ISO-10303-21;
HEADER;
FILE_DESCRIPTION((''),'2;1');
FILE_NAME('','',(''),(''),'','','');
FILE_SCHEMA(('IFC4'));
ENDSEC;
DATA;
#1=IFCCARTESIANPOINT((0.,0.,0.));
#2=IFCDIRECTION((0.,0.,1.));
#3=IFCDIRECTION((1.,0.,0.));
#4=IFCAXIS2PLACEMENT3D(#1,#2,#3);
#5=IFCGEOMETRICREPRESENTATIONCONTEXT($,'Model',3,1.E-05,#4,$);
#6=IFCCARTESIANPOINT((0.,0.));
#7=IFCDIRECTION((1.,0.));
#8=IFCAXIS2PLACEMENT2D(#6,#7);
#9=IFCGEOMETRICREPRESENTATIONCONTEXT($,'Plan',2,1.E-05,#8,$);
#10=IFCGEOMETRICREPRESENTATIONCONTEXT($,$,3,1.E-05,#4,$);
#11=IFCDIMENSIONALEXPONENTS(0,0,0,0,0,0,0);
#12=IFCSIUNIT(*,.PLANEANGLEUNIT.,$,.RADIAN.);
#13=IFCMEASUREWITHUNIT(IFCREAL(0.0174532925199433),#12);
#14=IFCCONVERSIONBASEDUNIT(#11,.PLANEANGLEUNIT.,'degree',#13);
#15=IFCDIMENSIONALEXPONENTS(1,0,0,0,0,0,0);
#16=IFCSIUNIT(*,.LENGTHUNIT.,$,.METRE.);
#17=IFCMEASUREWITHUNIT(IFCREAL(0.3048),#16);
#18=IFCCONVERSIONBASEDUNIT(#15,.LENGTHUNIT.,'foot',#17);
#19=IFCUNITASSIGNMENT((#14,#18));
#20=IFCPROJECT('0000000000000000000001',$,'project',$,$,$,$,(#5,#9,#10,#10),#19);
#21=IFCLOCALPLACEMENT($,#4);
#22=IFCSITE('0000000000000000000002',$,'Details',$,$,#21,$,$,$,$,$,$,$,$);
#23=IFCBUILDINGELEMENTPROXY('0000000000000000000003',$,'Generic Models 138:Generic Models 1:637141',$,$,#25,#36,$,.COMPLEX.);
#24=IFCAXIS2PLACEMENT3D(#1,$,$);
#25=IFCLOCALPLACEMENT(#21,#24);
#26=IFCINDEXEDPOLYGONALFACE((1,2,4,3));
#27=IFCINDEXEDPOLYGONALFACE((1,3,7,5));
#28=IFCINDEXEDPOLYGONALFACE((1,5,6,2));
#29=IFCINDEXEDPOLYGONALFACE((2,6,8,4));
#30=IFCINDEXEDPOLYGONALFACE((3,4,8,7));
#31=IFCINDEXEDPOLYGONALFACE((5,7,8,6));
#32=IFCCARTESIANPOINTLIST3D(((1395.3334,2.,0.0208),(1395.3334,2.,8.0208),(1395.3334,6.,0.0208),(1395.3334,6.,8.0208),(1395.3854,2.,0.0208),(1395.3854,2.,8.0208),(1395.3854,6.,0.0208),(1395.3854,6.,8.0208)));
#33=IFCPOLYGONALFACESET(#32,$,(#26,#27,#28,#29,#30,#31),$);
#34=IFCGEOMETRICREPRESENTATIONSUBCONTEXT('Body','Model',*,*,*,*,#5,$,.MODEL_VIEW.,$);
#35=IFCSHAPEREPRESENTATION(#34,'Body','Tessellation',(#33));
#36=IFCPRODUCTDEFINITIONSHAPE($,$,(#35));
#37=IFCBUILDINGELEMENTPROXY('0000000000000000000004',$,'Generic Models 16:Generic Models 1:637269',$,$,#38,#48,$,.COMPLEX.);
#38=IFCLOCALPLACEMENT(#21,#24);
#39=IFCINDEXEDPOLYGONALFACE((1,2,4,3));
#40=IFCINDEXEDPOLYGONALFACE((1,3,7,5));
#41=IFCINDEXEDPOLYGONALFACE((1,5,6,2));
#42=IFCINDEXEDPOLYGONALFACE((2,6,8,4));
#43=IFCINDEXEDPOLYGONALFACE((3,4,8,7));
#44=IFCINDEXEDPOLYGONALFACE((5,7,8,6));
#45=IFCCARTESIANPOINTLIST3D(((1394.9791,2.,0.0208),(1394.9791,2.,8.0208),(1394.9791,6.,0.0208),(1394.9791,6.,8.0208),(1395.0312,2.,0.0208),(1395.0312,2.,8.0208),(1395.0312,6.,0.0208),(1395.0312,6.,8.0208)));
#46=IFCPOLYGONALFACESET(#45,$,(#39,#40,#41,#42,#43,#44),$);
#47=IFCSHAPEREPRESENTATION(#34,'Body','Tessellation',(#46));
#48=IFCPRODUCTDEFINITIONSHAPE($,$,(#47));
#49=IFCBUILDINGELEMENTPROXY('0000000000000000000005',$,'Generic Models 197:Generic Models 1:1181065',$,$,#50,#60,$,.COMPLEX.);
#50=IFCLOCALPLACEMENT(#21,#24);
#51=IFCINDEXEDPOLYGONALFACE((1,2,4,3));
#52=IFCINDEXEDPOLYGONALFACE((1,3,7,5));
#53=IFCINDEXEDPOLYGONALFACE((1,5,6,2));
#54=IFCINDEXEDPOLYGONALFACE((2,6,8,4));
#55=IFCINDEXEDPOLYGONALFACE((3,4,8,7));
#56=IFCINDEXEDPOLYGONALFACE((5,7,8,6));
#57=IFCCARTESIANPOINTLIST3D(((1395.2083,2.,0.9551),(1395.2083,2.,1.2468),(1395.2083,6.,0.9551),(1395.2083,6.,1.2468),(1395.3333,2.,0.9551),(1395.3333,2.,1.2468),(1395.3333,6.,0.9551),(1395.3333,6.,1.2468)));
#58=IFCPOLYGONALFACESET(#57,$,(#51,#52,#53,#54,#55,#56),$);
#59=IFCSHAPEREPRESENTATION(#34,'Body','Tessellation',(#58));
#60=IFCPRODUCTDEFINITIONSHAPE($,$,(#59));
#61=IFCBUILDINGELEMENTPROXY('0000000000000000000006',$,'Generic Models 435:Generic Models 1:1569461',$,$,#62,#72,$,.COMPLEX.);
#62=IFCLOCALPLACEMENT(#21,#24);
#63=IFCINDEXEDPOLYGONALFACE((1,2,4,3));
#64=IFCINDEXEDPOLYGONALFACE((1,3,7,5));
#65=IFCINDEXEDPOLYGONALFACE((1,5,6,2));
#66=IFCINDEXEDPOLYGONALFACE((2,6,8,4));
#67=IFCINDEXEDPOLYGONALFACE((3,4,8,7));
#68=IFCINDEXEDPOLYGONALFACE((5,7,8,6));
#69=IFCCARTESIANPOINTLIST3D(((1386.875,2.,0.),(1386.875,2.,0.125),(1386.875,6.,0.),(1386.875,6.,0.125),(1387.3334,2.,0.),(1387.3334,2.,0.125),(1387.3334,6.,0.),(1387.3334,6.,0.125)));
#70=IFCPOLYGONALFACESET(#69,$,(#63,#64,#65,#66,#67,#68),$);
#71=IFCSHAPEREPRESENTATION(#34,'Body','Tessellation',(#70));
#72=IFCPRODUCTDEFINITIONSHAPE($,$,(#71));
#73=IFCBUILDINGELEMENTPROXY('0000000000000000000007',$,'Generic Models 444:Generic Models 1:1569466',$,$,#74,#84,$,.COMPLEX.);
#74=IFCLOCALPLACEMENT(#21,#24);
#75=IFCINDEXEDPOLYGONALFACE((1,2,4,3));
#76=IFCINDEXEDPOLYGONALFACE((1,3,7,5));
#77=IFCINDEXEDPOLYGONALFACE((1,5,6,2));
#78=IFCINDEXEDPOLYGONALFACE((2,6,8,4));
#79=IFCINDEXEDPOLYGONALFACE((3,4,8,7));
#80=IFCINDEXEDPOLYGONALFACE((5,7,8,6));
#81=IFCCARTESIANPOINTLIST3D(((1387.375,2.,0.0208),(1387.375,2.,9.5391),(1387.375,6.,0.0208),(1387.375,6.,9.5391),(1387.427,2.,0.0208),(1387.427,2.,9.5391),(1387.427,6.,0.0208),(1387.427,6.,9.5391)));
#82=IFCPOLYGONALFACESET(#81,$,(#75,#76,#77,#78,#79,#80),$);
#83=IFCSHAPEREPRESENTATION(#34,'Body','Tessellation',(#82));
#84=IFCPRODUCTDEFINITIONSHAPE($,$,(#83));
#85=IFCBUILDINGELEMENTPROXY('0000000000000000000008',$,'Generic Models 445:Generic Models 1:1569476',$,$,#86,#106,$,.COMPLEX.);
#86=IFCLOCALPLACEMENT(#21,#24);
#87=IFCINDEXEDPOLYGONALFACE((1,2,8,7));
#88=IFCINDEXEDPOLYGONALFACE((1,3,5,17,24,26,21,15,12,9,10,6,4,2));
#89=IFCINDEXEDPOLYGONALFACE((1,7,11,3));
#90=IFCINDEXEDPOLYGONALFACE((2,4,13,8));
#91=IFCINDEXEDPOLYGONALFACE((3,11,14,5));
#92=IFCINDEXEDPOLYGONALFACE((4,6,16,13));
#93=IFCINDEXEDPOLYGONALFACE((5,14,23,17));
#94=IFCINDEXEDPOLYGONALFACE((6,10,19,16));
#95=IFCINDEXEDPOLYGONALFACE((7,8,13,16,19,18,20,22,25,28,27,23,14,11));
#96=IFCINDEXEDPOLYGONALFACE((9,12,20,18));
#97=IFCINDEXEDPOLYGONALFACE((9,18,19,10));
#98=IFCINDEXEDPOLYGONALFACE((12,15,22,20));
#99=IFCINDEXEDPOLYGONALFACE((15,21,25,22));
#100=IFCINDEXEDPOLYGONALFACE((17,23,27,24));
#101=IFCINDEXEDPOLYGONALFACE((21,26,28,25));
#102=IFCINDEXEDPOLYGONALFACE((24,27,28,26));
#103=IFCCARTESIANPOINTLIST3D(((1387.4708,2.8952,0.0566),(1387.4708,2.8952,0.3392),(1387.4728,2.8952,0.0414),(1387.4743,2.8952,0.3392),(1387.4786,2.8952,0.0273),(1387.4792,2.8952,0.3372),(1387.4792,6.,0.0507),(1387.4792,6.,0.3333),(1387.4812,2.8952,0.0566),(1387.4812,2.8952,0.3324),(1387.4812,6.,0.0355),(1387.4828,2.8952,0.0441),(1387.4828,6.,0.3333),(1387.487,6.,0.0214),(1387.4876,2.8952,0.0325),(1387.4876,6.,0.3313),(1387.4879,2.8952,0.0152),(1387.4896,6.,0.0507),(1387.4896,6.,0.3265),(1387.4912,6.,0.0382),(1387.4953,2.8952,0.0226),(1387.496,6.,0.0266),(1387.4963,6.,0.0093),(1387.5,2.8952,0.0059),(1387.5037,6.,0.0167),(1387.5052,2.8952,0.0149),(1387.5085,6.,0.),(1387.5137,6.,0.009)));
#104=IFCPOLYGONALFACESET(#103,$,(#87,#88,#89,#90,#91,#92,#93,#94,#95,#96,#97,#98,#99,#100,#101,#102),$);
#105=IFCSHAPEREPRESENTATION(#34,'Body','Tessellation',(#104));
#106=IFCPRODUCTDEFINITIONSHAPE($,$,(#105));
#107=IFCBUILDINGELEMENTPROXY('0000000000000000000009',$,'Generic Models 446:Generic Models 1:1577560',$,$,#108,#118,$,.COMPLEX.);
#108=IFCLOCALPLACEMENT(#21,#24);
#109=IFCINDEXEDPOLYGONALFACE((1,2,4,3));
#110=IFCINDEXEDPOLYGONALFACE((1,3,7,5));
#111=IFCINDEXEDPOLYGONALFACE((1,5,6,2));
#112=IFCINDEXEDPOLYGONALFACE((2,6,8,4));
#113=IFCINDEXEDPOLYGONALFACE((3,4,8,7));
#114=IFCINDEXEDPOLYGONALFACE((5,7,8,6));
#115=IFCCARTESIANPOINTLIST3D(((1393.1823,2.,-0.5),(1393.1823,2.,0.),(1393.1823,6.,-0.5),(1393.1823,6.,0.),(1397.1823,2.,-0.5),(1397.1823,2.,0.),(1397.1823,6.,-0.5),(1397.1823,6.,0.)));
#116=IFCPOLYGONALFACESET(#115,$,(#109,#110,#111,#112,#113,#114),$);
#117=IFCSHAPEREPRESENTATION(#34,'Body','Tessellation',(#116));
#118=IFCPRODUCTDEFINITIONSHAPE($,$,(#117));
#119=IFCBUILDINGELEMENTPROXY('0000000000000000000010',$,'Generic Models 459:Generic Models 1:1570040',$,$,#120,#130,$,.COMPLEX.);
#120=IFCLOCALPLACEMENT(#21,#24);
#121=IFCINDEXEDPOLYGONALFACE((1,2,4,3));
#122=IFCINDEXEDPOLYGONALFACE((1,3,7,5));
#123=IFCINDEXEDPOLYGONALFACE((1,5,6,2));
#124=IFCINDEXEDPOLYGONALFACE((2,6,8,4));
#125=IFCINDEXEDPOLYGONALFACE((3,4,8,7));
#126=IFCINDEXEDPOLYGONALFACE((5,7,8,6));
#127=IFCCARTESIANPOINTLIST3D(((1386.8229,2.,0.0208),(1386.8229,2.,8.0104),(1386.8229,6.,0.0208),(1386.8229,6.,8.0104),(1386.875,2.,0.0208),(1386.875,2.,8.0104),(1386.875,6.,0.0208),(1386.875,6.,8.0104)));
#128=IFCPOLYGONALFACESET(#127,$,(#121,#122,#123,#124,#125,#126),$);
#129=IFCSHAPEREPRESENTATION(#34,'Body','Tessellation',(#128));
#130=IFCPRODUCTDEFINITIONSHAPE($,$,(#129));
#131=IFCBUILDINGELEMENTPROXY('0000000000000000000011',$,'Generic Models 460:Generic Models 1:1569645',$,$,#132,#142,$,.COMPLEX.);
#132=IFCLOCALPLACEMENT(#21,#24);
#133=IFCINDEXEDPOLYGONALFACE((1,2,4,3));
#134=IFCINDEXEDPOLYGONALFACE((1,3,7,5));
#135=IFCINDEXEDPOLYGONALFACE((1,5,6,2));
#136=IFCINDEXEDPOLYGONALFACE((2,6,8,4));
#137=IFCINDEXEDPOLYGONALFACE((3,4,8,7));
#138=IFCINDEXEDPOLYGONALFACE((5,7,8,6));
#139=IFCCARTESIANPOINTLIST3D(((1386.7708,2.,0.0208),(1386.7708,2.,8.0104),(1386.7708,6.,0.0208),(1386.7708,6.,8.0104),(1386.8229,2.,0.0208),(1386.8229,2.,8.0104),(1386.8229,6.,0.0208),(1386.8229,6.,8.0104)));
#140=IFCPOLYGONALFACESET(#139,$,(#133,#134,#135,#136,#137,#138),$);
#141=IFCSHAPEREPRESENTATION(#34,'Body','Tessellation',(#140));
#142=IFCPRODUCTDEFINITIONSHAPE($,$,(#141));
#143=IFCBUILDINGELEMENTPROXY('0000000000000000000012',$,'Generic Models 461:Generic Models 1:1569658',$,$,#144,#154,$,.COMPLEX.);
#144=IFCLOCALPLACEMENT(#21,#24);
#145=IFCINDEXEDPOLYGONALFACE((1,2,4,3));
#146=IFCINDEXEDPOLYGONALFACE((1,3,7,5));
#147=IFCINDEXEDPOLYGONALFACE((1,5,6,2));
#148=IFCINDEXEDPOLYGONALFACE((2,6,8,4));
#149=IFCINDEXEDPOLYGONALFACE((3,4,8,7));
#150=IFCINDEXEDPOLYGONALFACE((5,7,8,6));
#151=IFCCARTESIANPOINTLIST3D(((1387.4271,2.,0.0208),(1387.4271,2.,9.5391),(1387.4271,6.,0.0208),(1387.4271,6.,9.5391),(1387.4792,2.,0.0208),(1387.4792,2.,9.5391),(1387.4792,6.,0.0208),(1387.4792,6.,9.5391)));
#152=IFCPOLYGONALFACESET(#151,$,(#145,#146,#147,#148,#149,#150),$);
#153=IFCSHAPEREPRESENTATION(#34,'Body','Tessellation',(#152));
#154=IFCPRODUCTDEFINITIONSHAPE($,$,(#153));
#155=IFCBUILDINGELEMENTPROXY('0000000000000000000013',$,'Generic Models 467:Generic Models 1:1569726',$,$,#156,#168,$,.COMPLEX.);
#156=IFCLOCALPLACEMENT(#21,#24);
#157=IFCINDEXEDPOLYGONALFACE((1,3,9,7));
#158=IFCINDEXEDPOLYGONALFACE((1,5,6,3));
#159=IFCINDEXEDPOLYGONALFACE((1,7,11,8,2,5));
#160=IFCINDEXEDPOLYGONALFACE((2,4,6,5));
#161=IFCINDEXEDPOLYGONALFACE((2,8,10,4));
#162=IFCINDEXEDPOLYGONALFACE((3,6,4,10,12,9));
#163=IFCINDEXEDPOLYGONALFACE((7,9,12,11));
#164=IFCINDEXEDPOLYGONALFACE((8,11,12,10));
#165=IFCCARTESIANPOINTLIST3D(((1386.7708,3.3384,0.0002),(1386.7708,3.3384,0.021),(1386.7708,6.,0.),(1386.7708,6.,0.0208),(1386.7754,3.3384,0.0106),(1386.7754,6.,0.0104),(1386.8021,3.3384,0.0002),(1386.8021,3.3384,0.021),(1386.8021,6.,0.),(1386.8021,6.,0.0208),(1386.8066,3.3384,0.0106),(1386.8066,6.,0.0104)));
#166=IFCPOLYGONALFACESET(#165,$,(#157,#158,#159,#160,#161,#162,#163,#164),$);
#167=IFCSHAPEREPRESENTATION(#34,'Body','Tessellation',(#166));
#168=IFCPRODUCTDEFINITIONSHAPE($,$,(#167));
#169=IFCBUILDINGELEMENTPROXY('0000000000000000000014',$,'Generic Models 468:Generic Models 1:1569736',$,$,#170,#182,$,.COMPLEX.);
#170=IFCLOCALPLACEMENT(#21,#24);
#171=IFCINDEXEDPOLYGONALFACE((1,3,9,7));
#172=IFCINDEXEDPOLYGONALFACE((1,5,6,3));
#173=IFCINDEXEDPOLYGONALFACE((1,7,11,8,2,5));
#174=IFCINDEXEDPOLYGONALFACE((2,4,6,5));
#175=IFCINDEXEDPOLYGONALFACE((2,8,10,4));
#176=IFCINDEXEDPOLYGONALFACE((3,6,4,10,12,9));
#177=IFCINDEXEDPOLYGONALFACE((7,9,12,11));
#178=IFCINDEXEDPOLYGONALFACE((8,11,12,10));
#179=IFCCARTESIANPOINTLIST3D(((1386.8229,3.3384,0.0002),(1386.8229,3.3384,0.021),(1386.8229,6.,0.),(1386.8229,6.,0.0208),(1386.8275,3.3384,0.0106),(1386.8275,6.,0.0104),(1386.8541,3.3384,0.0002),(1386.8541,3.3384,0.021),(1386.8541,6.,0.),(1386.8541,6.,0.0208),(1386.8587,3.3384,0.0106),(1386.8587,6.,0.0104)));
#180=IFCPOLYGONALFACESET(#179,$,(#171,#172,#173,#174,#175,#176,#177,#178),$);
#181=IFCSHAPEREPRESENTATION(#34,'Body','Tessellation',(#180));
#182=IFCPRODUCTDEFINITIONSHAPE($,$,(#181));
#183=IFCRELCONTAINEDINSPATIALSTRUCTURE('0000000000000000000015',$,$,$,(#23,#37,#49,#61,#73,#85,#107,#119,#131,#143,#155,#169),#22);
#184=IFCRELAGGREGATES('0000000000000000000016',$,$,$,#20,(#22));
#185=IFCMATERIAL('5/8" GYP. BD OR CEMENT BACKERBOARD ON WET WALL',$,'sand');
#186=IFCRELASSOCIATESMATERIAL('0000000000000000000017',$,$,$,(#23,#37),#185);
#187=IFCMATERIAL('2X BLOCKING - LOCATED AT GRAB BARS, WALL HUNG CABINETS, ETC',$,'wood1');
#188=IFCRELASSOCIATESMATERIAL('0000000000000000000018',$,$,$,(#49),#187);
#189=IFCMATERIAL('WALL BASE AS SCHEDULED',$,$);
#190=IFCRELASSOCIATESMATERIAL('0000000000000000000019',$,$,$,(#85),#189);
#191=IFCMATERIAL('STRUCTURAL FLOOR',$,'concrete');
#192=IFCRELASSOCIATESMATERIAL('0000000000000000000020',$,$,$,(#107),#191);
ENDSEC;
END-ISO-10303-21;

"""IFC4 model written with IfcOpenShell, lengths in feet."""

from ifc_helpers import new_model, entity, si_unit, converted_unit, frame, origin_with_axes, origin_2d_with_axis, place, context, subcontext, project, spatial, polyline, outline, extrude, material, element, save


model = new_model("IFC4")

# Units and contexts
model_context = context("Model", 3, precision=1e-05, world=origin_with_axes())
plan_context = context("Plan", 2, precision=1e-05, world=origin_2d_with_axis())
context_of_model = context(None, 3, precision=1e-05, world=origin_with_axes())
body_context = subcontext(model_context, "Body", "Model", "MODEL_VIEW")
ifc_project = project(units=[converted_unit("PLANEANGLEUNIT", "degree", entity("IfcReal", 0.0174532925199433), si_unit("PLANEANGLEUNIT", "RADIAN"), dimensions=[0, 0, 0, 0, 0, 0, 0]), converted_unit("LENGTHUNIT", "foot", entity("IfcReal", 0.3048), si_unit("LENGTHUNIT", "METRE"), dimensions=[1, 0, 0, 0, 0, 0, 0])], contexts=[model_context, plan_context, context_of_model, context_of_model])

# Site
site_placement = place(None, origin_with_axes())
site = spatial("IfcSite", under=ifc_project, at=site_placement, Name="Details")

# Building element proxies
ifc_material_1 = material(Name="5/8\" GYP. BD OR CEMENT BACKERBOARD ON WET WALL", Category="sand")
for number, where, z_axis, x_axis, name in (
    (1, (1395.3334, 6.0, 0.0208), (0.0, -1.0, 0.0), (0.0, 0.0, 1.0), "Generic Models 138:Generic Models 1:637141"),
    (2, (1394.9791, 6.0, 0.0208), (0.0, -1.0, 0.0), (0.0, 0.0, 1.0), "Generic Models 16:Generic Models 1:637269"),
):
    element("IfcBuildingElementProxy", number, at=place(site_placement, frame(where, z_axis=z_axis, x_axis=x_axis)), inside=site, material=ifc_material_1, Name=name, PredefinedType="COMPLEX", context=body_context, shape_type="SweptSolid", body=[
        extrude(outline(polyline([(-0.026, -4.0), (0.026, -4.0), (0.026, 4.0), (-0.026, 4.0), (-0.026, -4.0)])), frame((4.0, -0.026, 0.0), z_axis=(0.0, 0.0, -1.0), x_axis=(0.0, -1.0, 0.0)), (0.0, 0.0, -1.0), 4.0),
    ])
ifc_material_2 = material(Name="2X BLOCKING - LOCATED AT GRAB BARS, WALL HUNG CABINETS, ETC", Category="wood1")
proxy_1_placement = place(site_placement, frame((1395.2083, 6.0, 0.9551), z_axis=(0.0, -1.0, 0.0), x_axis=(0.0, 0.0, 1.0)))
element("IfcBuildingElementProxy", 3, at=proxy_1_placement, inside=site, material=ifc_material_2, Name="Generic Models 197:Generic Models 1:1181065", PredefinedType="COMPLEX", context=body_context, shape_type="SweptSolid", body=[
    extrude(outline(polyline([(-0.0625, -0.1458), (0.0625, -0.1458), (0.0625, 0.1458), (-0.0625, 0.1458), (-0.0625, -0.1458)])), frame((0.1458, -0.0625, 0.0), z_axis=(0.0, 0.0, -1.0), x_axis=(0.0, -1.0, 0.0)), (0.0, 0.0, -1.0), 4.0),
])
ifc_material_3 = material(Name="WALL BASE AS SCHEDULED")
proxy_2_placement = place(site_placement, frame((1386.875, 6.0, 0.0), z_axis=(0.0, -1.0, 0.0), x_axis=(0.0, 0.0, 1.0)))
element("IfcBuildingElementProxy", 4, at=proxy_2_placement, inside=site, Name="Generic Models 435:Generic Models 1:1569461", PredefinedType="COMPLEX", context=body_context, shape_type="SweptSolid", body=[
    extrude(outline(polyline([(-0.2292, -0.0625), (0.2292, -0.0625), (0.2292, 0.0625), (-0.2292, 0.0625), (-0.2292, -0.0625)])), frame((0.0625, -0.2292, 0.0), z_axis=(0.0, 0.0, -1.0), x_axis=(0.0, 1.0, 0.0)), (0.0, 0.0, -1.0), 4.0),
])
proxy_3_placement = place(site_placement, frame((1387.375, 6.0, 0.0208), z_axis=(0.0, -1.0, 0.0), x_axis=(0.0, 0.0, 1.0)))
element("IfcBuildingElementProxy", 5, at=proxy_3_placement, inside=site, Name="Generic Models 444:Generic Models 1:1569466", PredefinedType="COMPLEX", context=body_context, shape_type="SweptSolid", body=[
    extrude(outline(polyline([(-4.7591, -0.026), (4.7591, -0.026), (4.7591, 0.026), (-4.7591, 0.026), (-4.7591, -0.026)])), frame((4.7591, -0.026, 0.0), z_axis=(0.0, 0.0, -1.0), x_axis=(1.0, 0.0, 0.0)), (0.0, 0.0, -1.0), 4.0),
])
proxy_4_placement = place(site_placement, frame((1387.4792, 6.0, 0.0), z_axis=(0.0, -1.0, 0.0), x_axis=(0.0, 0.0, 1.0)))
element("IfcBuildingElementProxy", 6, at=proxy_4_placement, inside=site, material=ifc_material_3, Name="Generic Models 445:Generic Models 1:1569476", PredefinedType="COMPLEX", context=body_context, shape_type="SweptSolid", body=[
    extrude(outline(polyline([(0.2206, 0.0), (0.2204, 0.0036), (0.2182, 0.0083), (0.2132, 0.01), (-0.0621, -0.0058), (-0.0747, -0.0049), (-0.0865, -0.0007), (-0.0969, 0.0063), (-0.1051, 0.0158), (-0.1138, 0.0101), (-0.1038, -0.0014), (-0.0912, -0.01), (-0.0768, -0.0151), (-0.0615, -0.0162), (0.2206, 0.0)])), frame((0.113, -0.0126, 0.0), z_axis=(0.0, 0.0, -1.0), x_axis=(0.998358, 0.057286, 0.0)), (0.002054, -0.002598, -0.999995), 3.1048),
])
ifc_material_4 = material(Name="STRUCTURAL FLOOR", Category="concrete")
proxy_5_placement = place(site_placement, frame((1393.1823, 6.0, -0.5), z_axis=(0.0, -1.0, 0.0), x_axis=(0.0, 0.0, 1.0)))
element("IfcBuildingElementProxy", 7, at=proxy_5_placement, inside=site, material=ifc_material_4, Name="Generic Models 446:Generic Models 1:1577560", PredefinedType="COMPLEX", context=body_context, shape_type="SweptSolid", body=[
    extrude(outline(polyline([(-2.0, -0.25), (2.0, -0.25), (2.0, 0.25), (-2.0, 0.25), (-2.0, -0.25)])), frame((0.25, -2.0, 0.0), z_axis=(0.0, 0.0, -1.0), x_axis=(0.0, 1.0, 0.0)), (0.0, 0.0, -1.0), 4.0),
])
proxy_6_placement = place(site_placement, frame((1386.8229, 6.0, 0.0208), z_axis=(0.0, -1.0, 0.0), x_axis=(0.0, 0.0, 1.0)))
element("IfcBuildingElementProxy", 8, at=proxy_6_placement, inside=site, Name="Generic Models 459:Generic Models 1:1570040", PredefinedType="COMPLEX", context=body_context, shape_type="SweptSolid", body=[
    extrude(outline(polyline([(-3.9948, -0.026), (3.9948, -0.026), (3.9948, 0.026), (-3.9948, 0.026), (-3.9948, -0.026)])), frame((3.9948, -0.026, 0.0), z_axis=(0.0, 0.0, -1.0), x_axis=(-1.0, 0.0, 0.0)), (0.0, 0.0, -1.0), 4.0),
])
proxy_7_placement = place(site_placement, frame((1386.7708, 6.0, 0.0208), z_axis=(0.0, -1.0, 0.0), x_axis=(0.0, 0.0, 1.0)))
element("IfcBuildingElementProxy", 9, at=proxy_7_placement, inside=site, Name="Generic Models 460:Generic Models 1:1569645", PredefinedType="COMPLEX", context=body_context, shape_type="SweptSolid", body=[
    extrude(outline(polyline([(-3.9948, -0.026), (3.9948, -0.026), (3.9948, 0.026), (-3.9948, 0.026), (-3.9948, -0.026)])), frame((3.9948, -0.026, 0.0), z_axis=(0.0, 0.0, -1.0), x_axis=(1.0, 0.0, 0.0)), (0.0, 0.0, -1.0), 4.0),
])
proxy_8_placement = place(site_placement, frame((1387.4271, 6.0, 0.0208), z_axis=(0.0, -1.0, 0.0), x_axis=(0.0, 0.0, 1.0)))
element("IfcBuildingElementProxy", 10, at=proxy_8_placement, inside=site, Name="Generic Models 461:Generic Models 1:1569658", PredefinedType="COMPLEX", context=body_context, shape_type="SweptSolid", body=[
    extrude(outline(polyline([(-4.7591, -0.026), (4.7591, -0.026), (4.7591, 0.026), (-4.7591, 0.026), (-4.7591, -0.026)])), frame((4.7591, -0.026, 0.0), z_axis=(0.0, 0.0, -1.0), x_axis=(-1.0, 0.0, 0.0)), (0.0, 0.0, -1.0), 4.0),
])
for number, where, z_axis, x_axis, name in (
    (11, (1386.7708, 6.0, 0.0), (0.0, -1.0, 0.0), (0.0, 0.0, 1.0), "Generic Models 467:Generic Models 1:1569726"),
    (12, (1386.8229, 6.0, 0.0), (0.0, -1.0, 0.0), (0.0, 0.0, 1.0), "Generic Models 468:Generic Models 1:1569736"),
):
    element("IfcBuildingElementProxy", number, at=place(site_placement, frame(where, z_axis=z_axis, x_axis=x_axis)), inside=site, Name=name, PredefinedType="COMPLEX", context=body_context, shape_type="SweptSolid", body=[
        extrude(outline(polyline([(0.0201, 0.0), (-0.0066, 0.0162), (-0.016, 0.0097), (-0.0175, -0.0016), (0.0093, -0.0178), (0.0107, -0.0065), (0.0201, 0.0)])), frame((0.0104, -0.0172, 0.0), z_axis=(0.0, 0.0, -1.0), x_axis=(0.51911, 0.854708, 0.0)), (0.000035, 0.000056, -1.0), 2.6616),
    ])

save(model, "model.ifc")
